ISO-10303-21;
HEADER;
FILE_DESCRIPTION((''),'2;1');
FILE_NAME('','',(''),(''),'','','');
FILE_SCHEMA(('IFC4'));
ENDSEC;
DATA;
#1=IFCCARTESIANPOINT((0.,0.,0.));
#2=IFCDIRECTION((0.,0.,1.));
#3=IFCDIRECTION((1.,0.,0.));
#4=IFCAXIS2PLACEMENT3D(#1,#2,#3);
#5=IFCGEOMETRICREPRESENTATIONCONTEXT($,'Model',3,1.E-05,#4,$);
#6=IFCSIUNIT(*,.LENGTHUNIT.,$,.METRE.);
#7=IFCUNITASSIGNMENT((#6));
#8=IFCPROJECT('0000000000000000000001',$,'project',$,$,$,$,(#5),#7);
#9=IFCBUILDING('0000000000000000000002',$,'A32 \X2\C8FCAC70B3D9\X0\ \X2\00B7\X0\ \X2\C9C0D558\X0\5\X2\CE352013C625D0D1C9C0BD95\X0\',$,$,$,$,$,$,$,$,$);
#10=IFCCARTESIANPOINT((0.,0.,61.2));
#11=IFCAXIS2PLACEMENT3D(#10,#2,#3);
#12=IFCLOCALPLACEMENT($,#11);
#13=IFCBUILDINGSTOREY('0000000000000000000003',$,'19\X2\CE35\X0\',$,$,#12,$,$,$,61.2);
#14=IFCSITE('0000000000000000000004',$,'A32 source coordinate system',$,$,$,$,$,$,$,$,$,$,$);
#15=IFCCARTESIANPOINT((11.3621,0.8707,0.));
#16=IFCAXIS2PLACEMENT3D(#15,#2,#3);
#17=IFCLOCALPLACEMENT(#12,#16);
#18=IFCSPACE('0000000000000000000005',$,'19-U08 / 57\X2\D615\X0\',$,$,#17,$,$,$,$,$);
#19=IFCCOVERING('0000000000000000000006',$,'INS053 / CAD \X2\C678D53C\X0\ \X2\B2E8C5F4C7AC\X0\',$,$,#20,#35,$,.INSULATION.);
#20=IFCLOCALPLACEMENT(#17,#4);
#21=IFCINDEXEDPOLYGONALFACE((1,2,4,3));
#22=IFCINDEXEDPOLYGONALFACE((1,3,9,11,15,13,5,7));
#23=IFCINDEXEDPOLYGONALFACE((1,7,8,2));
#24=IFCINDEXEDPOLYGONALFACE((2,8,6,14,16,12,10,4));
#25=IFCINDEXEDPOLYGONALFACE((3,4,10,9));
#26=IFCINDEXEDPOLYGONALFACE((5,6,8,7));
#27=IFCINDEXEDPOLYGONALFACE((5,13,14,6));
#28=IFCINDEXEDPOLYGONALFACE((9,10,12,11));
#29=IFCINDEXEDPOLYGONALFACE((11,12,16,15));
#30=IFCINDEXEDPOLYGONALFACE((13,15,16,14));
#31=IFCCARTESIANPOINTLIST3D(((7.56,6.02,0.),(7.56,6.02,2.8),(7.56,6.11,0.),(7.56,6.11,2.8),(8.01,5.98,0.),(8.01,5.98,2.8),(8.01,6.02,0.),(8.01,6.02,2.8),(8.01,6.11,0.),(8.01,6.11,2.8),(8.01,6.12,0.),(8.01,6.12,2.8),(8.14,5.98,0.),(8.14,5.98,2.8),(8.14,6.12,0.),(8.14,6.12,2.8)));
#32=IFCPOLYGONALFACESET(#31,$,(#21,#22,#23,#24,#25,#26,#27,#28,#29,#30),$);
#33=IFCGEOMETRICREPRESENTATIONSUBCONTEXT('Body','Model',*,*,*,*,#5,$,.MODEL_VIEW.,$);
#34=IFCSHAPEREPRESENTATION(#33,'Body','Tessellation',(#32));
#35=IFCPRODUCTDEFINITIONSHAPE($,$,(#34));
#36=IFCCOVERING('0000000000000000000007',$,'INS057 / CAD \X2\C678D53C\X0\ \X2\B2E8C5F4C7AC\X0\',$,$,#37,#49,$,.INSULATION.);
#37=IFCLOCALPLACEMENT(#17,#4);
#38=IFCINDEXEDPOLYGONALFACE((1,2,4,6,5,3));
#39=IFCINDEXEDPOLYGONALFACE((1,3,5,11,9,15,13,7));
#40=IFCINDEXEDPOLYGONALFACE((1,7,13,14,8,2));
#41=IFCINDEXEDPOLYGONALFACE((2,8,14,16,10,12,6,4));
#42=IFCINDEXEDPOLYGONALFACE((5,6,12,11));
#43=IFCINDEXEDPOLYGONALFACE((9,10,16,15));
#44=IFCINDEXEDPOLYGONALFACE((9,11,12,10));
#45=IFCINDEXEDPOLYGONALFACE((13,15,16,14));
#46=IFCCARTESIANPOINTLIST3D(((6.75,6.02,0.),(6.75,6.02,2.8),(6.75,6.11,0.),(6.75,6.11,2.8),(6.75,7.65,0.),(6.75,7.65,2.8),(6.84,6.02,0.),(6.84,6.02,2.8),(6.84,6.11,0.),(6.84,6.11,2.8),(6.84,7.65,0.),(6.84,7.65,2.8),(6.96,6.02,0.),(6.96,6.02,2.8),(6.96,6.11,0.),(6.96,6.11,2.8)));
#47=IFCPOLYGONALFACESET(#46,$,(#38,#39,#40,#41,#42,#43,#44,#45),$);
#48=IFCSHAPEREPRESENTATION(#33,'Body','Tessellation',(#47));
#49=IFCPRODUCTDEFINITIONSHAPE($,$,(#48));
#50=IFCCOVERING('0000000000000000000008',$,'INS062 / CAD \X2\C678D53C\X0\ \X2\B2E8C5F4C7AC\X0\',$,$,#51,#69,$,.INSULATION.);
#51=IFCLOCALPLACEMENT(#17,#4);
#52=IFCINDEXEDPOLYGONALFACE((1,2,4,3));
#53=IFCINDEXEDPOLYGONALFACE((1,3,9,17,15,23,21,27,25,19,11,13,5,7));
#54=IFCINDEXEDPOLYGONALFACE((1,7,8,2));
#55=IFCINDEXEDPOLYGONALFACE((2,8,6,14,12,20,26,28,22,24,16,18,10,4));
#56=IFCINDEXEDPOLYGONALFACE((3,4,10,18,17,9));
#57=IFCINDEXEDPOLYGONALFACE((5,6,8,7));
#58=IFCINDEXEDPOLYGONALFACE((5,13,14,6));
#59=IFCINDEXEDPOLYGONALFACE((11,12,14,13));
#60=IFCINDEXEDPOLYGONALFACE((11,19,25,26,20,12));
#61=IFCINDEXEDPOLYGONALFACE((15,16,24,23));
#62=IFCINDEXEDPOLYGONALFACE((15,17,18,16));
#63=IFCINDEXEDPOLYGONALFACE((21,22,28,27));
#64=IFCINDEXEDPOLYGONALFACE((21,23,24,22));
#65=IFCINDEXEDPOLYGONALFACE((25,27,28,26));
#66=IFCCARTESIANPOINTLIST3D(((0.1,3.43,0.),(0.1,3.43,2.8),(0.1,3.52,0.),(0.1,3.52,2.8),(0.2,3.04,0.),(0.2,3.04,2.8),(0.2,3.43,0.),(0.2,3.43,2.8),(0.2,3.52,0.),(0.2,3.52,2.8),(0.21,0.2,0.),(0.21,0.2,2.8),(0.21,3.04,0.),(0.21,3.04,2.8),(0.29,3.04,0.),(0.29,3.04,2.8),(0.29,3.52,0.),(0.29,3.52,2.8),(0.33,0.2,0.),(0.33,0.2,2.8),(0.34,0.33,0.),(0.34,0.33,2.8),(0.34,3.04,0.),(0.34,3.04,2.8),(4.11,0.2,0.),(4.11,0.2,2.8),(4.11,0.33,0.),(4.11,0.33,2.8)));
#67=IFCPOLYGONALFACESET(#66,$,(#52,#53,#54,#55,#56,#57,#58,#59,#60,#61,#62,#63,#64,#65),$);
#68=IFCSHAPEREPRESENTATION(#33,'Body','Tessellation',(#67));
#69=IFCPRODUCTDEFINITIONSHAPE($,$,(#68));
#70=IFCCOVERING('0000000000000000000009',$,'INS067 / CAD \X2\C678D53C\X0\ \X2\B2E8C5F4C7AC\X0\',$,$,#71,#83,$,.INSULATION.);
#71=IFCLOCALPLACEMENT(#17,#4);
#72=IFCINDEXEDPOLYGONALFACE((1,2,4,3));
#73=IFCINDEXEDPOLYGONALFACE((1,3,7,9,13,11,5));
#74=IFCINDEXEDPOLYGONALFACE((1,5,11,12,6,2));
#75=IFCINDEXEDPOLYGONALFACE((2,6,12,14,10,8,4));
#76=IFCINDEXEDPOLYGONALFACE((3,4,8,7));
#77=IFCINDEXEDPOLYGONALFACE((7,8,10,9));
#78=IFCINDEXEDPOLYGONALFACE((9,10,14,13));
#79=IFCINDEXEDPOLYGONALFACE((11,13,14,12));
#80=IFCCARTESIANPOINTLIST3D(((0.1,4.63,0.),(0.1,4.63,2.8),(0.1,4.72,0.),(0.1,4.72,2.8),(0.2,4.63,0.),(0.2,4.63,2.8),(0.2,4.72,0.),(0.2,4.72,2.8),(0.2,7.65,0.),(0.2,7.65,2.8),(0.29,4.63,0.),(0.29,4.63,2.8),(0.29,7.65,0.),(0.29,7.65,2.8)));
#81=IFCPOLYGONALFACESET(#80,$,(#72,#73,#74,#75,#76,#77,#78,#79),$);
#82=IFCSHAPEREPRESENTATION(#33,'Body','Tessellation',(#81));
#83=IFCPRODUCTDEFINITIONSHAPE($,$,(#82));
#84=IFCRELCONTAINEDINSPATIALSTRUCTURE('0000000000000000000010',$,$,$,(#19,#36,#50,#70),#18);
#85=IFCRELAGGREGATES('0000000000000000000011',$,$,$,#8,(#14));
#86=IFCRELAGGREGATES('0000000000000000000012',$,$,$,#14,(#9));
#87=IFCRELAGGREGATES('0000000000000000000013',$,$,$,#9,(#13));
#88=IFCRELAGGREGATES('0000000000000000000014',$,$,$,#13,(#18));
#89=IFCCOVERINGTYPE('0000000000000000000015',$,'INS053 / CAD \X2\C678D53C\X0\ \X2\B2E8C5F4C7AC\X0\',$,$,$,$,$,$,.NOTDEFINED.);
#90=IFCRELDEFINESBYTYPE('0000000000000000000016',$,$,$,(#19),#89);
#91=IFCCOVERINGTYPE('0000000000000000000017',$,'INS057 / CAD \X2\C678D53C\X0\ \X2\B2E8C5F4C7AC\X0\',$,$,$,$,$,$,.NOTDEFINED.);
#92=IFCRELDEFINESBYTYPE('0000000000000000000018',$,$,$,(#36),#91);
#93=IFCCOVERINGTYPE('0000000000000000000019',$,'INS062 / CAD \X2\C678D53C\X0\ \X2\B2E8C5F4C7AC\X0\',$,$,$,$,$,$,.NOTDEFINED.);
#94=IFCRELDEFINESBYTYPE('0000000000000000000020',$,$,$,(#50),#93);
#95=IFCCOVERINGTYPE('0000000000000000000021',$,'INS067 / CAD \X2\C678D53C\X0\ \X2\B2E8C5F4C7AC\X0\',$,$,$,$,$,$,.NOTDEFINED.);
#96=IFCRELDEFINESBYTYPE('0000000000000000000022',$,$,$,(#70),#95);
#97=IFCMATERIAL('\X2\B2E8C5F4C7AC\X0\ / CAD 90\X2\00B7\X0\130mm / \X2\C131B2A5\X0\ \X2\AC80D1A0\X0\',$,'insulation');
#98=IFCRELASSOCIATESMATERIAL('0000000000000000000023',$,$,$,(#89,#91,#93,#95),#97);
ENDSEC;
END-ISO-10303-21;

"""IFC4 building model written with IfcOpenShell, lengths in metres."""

from ifc_helpers import new_model, si_unit, frame, origin, origin_with_axes, place, context, subcontext, project, spatial, polyline, outline, extrude, source, transform, mapped, material, type_object, type_shapes, element, save


model = new_model("IFC4")

# Units and contexts
model_context = context("Model", 3, precision=1e-05, world=origin_with_axes())
body_context = subcontext(model_context, "Body", "Model", "MODEL_VIEW")
ifc_project = project(units=[si_unit("LENGTHUNIT", "METRE")], contexts=[model_context])

# Site, building, storey, space
site = spatial("IfcSite", under=ifc_project, Name="A32 source coordinate system")
building = spatial("IfcBuilding", under=site, Name="A32 주거동 · 지하5층–옥탑지붕")
storey_placement = place(None, frame((0.0, 0.0, 61.2), z_axis=(0.0, 0.0, 1.0), x_axis=(1.0, 0.0, 0.0)))
storey = spatial("IfcBuildingStorey", under=building, at=storey_placement, Name="19층", Elevation=61.2)
space_1_placement = place(storey_placement, frame((11.3621, 0.8707, 0.0), z_axis=(0.0, 0.0, 1.0), x_axis=(1.0, 0.0, 0.0)))
space_1 = spatial("IfcSpace", under=storey, at=space_1_placement, Name="19-U08 / 57형")

# Coverings
ifc_material = material(Name="단열재 / CAD 90·130mm / 성능 검토", Category="insulation")
covering_type_1 = type_object("IfcCoveringType", Name="INS053 / CAD 외피 단열재", PredefinedType="NOTDEFINED", material=ifc_material)
shared_shape_1 = source(origin(), body_context, "Body", "SweptSolid", [
    extrude(outline(polyline([(8.01, 6.12), (8.14, 6.12), (8.14, 5.98), (8.01, 5.98), (8.01, 6.02), (7.56, 6.02), (7.56, 6.11), (8.01, 6.11), (8.01, 6.12)])), origin(), (0.0, 0.0, 1.0), 2.8),
])
type_shapes(covering_type_1, [shared_shape_1])
covering_1_placement = place(space_1_placement, origin_with_axes())
element("IfcCovering", 1, at=covering_1_placement, inside=space_1, type_object=covering_type_1, Name="INS053 / CAD 외피 단열재", PredefinedType="INSULATION", context=body_context, shape_type="MappedRepresentation", body=[
    mapped(shared_shape_1, transform((0.0, 0.0, 0.0), scale=1.0)),
])
covering_type_2 = type_object("IfcCoveringType", Name="INS057 / CAD 외피 단열재", PredefinedType="NOTDEFINED", material=ifc_material)
shared_shape_2 = source(origin(), body_context, "Body", "SweptSolid", [
    extrude(outline(polyline([(6.84, 6.11), (6.96, 6.11), (6.96, 6.02), (6.84, 6.02), (6.75, 6.02), (6.75, 6.11), (6.75, 7.65), (6.84, 7.65), (6.84, 6.11)])), origin(), (0.0, 0.0, 1.0), 2.8),
])
type_shapes(covering_type_2, [shared_shape_2])
covering_2_placement = place(space_1_placement, origin_with_axes())
element("IfcCovering", 2, at=covering_2_placement, inside=space_1, type_object=covering_type_2, Name="INS057 / CAD 외피 단열재", PredefinedType="INSULATION", context=body_context, shape_type="MappedRepresentation", body=[
    mapped(shared_shape_2, transform((0.0, 0.0, 0.0), scale=1.0)),
])
covering_type_3 = type_object("IfcCoveringType", Name="INS062 / CAD 외피 단열재", PredefinedType="NOTDEFINED", material=ifc_material)
shared_shape_3 = source(origin(), body_context, "Body", "SweptSolid", [
    extrude(outline(polyline([(4.11, 0.2), (0.33, 0.2), (0.21, 0.2), (0.21, 3.04), (0.2, 3.04), (0.2, 3.43), (0.1, 3.43), (0.1, 3.52), (0.2, 3.52), (0.29, 3.52), (0.29, 3.04), (0.34, 3.04), (0.34, 0.33), (4.11, 0.33), (4.11, 0.2)])), origin(), (0.0, 0.0, 1.0), 2.8),
])
type_shapes(covering_type_3, [shared_shape_3])
covering_3_placement = place(space_1_placement, origin_with_axes())
element("IfcCovering", 3, at=covering_3_placement, inside=space_1, type_object=covering_type_3, Name="INS062 / CAD 외피 단열재", PredefinedType="INSULATION", context=body_context, shape_type="MappedRepresentation", body=[
    mapped(shared_shape_3, transform((0.0, 0.0, 0.0), scale=1.0)),
])
covering_type_4 = type_object("IfcCoveringType", Name="INS067 / CAD 외피 단열재", PredefinedType="NOTDEFINED", material=ifc_material)
shared_shape_4 = source(origin(), body_context, "Body", "SweptSolid", [
    extrude(outline(polyline([(0.1, 4.72), (0.2, 4.72), (0.2, 7.65), (0.29, 7.65), (0.29, 4.63), (0.2, 4.63), (0.1, 4.63), (0.1, 4.72)])), origin(), (0.0, 0.0, 1.0), 2.8),
])
type_shapes(covering_type_4, [shared_shape_4])
covering_4_placement = place(space_1_placement, origin_with_axes())
element("IfcCovering", 4, at=covering_4_placement, inside=space_1, type_object=covering_type_4, Name="INS067 / CAD 외피 단열재", PredefinedType="INSULATION", context=body_context, shape_type="MappedRepresentation", body=[
    mapped(shared_shape_4, transform((0.0, 0.0, 0.0), scale=1.0)),
])

save(model, "model.ifc")
